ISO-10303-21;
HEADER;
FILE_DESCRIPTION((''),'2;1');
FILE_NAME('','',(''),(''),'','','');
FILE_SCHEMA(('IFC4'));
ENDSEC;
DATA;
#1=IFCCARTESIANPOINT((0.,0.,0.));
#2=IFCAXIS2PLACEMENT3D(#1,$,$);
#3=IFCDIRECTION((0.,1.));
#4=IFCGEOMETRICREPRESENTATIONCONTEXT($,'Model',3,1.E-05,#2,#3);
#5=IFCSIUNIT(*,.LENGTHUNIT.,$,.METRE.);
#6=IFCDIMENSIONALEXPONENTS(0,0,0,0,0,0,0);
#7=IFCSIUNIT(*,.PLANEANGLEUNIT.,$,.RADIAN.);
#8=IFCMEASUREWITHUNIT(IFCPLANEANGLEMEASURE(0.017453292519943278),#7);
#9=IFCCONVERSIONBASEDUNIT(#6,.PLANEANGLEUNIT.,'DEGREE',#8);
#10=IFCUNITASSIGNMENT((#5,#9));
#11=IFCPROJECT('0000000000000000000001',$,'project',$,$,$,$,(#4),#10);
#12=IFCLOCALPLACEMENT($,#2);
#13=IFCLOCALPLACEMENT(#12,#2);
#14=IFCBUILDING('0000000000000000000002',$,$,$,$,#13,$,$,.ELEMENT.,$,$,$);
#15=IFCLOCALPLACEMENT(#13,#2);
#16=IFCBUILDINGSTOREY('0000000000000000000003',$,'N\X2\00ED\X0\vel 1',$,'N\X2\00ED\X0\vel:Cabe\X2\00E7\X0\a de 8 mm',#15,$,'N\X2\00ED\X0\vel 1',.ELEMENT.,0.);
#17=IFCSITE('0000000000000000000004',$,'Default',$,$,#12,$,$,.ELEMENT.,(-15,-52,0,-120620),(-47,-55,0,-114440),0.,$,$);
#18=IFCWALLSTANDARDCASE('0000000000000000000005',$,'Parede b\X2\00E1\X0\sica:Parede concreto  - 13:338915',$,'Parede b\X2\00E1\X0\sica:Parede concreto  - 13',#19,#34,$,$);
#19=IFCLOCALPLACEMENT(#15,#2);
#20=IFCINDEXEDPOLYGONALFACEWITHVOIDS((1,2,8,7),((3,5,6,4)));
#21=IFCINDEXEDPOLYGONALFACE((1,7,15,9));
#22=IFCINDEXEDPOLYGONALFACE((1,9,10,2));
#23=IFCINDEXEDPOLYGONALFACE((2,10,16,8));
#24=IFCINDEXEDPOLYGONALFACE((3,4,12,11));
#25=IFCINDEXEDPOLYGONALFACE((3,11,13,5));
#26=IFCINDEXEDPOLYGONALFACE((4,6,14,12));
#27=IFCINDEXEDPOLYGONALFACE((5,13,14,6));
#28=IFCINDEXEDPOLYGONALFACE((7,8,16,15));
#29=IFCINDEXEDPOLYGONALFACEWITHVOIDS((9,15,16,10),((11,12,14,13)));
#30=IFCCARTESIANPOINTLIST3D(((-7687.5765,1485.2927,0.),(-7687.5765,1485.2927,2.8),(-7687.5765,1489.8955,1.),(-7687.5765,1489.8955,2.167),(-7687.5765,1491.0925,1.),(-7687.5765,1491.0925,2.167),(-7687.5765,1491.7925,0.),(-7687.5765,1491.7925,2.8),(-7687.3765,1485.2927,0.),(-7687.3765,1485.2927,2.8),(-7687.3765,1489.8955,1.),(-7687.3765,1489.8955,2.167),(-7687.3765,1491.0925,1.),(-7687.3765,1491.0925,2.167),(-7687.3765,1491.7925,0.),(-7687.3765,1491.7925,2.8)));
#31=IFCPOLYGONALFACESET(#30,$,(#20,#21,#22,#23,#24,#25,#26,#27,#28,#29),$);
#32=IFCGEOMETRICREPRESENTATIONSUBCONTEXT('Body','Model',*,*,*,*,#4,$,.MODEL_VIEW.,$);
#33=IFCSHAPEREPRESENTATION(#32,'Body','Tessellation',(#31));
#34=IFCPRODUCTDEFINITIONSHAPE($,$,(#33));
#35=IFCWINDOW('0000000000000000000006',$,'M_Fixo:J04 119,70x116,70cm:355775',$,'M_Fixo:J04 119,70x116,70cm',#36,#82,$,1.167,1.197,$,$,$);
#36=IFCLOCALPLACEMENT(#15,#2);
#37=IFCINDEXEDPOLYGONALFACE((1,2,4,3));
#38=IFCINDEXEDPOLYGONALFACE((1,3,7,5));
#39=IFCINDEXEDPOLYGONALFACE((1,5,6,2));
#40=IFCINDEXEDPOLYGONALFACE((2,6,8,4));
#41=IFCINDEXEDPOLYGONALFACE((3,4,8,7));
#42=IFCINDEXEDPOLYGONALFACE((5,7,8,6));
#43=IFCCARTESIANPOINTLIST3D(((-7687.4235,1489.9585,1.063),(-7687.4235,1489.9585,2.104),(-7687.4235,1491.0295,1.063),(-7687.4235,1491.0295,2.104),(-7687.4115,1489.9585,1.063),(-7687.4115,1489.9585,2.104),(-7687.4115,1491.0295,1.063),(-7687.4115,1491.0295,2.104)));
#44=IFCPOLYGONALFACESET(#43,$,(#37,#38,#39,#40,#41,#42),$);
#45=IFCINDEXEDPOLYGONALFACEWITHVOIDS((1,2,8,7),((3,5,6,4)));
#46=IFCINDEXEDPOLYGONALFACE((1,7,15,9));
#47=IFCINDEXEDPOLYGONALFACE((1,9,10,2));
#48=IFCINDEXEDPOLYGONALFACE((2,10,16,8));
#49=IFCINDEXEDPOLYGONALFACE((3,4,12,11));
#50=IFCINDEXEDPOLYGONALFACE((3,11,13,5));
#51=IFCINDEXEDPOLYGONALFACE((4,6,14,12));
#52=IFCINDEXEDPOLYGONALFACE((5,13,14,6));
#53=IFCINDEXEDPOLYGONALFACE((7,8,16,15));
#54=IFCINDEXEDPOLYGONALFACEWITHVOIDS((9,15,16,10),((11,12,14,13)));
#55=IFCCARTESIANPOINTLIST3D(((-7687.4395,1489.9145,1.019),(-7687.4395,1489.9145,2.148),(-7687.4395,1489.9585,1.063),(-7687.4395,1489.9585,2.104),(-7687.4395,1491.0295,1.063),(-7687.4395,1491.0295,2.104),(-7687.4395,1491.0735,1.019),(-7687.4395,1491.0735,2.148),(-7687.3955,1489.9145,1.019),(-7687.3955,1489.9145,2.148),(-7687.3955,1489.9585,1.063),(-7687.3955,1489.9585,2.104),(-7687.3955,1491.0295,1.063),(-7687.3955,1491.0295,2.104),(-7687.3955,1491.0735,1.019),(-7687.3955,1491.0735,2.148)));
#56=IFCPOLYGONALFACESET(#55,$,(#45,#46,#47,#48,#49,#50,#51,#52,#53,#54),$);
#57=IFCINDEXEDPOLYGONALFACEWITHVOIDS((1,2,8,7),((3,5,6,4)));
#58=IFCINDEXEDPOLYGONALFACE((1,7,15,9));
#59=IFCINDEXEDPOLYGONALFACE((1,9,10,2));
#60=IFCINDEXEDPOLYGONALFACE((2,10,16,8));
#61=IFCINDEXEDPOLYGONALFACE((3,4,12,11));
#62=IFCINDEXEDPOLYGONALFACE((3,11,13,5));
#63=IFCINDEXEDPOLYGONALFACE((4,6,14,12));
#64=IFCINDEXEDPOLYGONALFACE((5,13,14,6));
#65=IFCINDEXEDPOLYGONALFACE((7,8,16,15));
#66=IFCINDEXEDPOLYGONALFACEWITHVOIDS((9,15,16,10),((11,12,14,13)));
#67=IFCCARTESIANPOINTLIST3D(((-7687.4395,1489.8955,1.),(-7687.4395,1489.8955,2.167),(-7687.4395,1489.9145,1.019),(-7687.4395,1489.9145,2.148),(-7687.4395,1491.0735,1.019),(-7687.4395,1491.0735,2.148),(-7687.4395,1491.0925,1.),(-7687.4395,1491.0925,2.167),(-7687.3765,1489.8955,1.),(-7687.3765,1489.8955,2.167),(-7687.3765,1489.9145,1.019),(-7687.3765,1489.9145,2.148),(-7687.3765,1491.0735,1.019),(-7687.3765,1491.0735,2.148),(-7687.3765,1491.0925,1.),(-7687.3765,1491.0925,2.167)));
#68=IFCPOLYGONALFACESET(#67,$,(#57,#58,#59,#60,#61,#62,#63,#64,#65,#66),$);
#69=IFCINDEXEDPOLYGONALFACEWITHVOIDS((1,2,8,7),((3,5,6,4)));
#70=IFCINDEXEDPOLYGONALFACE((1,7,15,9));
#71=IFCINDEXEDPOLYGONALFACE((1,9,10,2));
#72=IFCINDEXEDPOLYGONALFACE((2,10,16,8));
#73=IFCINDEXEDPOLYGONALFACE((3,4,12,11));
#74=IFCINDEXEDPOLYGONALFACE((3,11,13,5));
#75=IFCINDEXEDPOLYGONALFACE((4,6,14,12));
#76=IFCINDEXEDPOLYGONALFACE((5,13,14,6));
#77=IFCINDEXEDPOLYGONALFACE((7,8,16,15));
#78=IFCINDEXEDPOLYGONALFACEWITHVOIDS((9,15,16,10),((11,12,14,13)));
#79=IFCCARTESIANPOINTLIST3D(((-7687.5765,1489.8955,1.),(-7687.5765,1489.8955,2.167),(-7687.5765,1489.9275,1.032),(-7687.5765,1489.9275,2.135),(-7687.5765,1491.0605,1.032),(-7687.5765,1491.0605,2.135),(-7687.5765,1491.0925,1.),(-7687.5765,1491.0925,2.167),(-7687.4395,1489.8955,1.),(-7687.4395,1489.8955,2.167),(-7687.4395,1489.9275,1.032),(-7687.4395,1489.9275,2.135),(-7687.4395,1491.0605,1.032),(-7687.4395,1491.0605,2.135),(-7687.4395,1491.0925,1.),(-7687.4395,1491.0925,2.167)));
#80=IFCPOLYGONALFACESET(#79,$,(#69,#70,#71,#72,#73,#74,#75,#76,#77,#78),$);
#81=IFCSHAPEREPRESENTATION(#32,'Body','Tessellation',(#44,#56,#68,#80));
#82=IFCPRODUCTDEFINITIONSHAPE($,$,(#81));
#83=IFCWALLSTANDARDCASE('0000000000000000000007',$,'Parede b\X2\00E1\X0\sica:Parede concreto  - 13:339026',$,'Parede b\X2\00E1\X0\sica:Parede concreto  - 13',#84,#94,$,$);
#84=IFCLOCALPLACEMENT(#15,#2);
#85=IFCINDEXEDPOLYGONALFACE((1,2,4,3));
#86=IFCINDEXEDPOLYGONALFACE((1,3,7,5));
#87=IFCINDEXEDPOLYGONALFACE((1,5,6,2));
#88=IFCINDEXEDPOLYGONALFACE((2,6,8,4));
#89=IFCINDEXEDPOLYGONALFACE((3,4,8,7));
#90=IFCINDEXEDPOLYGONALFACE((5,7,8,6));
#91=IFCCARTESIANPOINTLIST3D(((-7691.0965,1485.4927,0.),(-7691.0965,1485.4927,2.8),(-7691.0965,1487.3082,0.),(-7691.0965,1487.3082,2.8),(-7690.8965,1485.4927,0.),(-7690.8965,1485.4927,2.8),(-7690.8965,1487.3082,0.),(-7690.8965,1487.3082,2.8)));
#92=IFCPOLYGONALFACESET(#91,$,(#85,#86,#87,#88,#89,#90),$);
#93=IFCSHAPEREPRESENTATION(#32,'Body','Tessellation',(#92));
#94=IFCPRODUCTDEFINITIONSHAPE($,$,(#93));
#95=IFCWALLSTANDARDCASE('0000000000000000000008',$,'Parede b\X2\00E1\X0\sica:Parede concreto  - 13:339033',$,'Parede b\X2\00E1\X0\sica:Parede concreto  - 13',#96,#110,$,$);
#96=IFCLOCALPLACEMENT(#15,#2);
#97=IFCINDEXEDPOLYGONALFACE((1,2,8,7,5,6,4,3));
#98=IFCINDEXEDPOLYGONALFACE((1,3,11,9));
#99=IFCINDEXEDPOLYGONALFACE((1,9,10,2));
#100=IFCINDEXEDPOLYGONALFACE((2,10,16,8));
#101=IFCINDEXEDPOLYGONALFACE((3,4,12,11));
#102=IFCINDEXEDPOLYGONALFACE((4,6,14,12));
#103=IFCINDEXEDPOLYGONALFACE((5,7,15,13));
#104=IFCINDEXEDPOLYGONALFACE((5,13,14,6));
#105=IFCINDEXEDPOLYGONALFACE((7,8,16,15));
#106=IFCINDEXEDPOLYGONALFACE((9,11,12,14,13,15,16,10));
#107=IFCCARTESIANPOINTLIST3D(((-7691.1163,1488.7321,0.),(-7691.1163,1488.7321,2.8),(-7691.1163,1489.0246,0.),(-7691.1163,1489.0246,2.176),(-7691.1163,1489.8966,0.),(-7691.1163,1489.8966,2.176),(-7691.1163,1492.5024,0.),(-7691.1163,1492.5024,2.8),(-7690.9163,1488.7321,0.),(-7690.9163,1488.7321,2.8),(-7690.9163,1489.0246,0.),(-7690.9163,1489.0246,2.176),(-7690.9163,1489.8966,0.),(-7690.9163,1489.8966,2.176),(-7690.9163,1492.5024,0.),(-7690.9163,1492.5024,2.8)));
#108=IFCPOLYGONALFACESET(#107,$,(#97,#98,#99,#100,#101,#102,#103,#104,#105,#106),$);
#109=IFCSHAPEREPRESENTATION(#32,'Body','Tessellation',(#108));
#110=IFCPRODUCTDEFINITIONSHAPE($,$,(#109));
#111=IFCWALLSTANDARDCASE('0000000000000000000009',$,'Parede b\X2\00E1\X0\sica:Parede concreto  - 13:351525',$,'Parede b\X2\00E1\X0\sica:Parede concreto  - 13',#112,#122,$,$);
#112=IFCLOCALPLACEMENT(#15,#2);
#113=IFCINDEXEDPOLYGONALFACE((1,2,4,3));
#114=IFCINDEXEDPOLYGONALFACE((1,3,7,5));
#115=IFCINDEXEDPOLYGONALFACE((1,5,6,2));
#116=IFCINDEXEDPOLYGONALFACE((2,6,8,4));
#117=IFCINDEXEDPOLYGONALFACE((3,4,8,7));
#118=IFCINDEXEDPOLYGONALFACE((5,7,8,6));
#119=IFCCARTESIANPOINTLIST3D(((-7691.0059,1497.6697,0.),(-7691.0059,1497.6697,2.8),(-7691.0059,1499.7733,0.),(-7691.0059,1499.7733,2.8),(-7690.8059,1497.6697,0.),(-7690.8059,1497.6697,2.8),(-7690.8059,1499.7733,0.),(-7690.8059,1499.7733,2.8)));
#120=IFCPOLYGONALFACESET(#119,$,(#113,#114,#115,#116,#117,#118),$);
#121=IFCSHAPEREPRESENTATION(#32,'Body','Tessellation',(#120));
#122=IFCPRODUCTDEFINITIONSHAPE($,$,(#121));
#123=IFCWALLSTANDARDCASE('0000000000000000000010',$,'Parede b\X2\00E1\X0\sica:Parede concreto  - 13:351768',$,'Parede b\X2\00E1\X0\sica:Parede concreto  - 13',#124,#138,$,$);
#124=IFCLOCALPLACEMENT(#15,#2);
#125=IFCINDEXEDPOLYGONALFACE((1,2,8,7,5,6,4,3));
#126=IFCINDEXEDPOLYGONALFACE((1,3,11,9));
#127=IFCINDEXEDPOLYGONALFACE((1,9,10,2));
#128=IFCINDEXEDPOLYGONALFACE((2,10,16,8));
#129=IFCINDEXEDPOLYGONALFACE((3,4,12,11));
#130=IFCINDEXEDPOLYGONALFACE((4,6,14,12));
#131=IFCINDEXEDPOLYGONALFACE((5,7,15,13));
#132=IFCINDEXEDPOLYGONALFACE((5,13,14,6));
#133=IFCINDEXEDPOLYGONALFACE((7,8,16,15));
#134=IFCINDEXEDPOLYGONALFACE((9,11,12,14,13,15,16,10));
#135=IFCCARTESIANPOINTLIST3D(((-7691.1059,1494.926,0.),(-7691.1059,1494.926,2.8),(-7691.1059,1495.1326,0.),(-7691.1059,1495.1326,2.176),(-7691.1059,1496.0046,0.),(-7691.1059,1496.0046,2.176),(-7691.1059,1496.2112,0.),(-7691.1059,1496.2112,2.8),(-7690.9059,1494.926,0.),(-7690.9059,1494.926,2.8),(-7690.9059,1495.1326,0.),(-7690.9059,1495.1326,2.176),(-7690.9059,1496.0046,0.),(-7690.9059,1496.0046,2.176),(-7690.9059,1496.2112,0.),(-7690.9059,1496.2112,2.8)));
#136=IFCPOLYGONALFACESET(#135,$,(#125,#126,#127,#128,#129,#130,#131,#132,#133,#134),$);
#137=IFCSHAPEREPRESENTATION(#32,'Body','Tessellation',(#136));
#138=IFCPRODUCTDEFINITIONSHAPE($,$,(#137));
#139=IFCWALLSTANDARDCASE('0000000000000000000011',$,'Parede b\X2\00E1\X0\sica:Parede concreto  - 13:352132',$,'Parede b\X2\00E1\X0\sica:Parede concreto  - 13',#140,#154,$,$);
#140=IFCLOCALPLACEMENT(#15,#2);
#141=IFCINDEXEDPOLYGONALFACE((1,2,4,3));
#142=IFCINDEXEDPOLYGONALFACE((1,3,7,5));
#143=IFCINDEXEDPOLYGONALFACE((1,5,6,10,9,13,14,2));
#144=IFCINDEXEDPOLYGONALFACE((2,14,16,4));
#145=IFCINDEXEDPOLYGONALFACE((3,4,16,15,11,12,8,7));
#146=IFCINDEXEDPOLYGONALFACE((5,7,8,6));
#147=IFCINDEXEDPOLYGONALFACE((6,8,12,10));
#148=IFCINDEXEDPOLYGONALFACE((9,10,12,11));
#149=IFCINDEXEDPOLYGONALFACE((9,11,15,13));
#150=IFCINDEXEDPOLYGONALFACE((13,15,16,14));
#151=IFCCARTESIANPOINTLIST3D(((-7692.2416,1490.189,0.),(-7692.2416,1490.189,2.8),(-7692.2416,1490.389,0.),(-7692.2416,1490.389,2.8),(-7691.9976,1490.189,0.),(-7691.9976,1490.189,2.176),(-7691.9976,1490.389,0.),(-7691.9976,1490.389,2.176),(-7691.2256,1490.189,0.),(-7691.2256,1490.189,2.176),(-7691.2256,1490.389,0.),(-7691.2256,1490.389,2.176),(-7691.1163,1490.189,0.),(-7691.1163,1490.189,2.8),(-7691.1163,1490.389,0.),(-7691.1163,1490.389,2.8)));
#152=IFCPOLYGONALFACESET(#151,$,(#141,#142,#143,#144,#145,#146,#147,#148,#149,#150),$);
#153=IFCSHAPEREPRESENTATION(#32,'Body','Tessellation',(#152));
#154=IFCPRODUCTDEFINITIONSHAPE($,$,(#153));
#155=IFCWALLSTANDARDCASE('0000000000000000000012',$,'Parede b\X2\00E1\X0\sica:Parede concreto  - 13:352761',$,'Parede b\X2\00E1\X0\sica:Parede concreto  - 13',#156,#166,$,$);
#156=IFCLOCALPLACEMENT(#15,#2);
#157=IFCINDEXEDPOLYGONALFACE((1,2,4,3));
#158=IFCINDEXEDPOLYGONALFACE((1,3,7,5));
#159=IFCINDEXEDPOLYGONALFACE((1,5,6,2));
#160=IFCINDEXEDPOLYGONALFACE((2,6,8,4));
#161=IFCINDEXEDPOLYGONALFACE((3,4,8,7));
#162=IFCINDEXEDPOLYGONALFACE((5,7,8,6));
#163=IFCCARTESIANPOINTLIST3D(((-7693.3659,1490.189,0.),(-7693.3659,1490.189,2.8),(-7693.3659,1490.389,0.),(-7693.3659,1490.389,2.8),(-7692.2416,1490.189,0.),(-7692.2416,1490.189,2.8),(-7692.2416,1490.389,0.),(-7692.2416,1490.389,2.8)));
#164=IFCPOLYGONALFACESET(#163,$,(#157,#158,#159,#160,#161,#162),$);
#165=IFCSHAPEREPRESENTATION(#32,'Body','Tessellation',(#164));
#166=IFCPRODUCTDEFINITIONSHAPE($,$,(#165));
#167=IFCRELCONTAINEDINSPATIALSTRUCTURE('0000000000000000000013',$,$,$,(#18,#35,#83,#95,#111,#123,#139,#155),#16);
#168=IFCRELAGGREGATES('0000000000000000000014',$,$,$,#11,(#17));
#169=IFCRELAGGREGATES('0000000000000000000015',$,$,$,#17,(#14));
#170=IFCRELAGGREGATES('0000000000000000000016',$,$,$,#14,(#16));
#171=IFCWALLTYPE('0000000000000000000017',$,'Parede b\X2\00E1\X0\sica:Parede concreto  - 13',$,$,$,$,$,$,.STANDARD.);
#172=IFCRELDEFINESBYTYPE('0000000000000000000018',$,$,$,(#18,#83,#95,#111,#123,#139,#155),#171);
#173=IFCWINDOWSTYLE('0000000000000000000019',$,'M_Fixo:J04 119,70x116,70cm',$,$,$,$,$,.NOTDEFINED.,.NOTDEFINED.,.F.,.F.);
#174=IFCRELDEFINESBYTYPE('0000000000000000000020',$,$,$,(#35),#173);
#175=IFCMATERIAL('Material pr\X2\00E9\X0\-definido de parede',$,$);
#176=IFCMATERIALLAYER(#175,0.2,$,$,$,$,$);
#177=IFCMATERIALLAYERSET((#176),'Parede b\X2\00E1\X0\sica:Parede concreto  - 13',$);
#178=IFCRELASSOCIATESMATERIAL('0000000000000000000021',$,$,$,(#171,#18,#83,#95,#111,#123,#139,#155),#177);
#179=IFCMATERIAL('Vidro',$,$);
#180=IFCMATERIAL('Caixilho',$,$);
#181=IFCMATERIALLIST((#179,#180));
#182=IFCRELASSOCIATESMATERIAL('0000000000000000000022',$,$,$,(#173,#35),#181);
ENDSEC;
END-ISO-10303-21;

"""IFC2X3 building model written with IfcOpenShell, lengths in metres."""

from ifc_helpers import new_model, entity, si_unit, converted_unit, direction, frame, frame_2d, origin, place, context, subcontext, project, spatial, polyline, rectangle, outline, extrude, source, transform, mapped, material, material_list, layer, layer_set, layer_usage, type_object, type_shapes, element, fill, save


model = new_model("IFC2X3")

# Units and contexts
model_context = context("Model", 3, precision=1e-05, world=origin(), true_north=direction((0.0, 1.0)))
body_context = subcontext(model_context, "Body", "Model", "MODEL_VIEW")
ifc_project = project(units=[si_unit("LENGTHUNIT", "METRE"), converted_unit("PLANEANGLEUNIT", "DEGREE", entity("IfcPlaneAngleMeasure", 0.017453292519943278), si_unit("PLANEANGLEUNIT", "RADIAN"), dimensions=[0, 0, 0, 0, 0, 0, 0])], contexts=[model_context])

# Site, building, storey
site_placement = place(None, origin())
site = spatial("IfcSite", under=ifc_project, at=site_placement, Name="Default", CompositionType="ELEMENT", RefLatitude=(-15, -52, 0, -120620), RefLongitude=(-47, -55, 0, -114440), RefElevation=0.0)
building_placement = place(site_placement, origin())
building = spatial("IfcBuilding", under=site, at=building_placement, CompositionType="ELEMENT")
storey_placement = place(building_placement, origin())
storey = spatial("IfcBuildingStorey", under=building, at=storey_placement, Name="Nível 1", ObjectType="Nível:Cabeça de 8 mm", LongName="Nível 1", CompositionType="ELEMENT", Elevation=0.0)

# Shared definitions
ifc_material_1 = material(Name="Material pré-definido de parede")
ifc_layer_1 = layer(ifc_material_1, 0.2)
ifc_layer_set_1 = layer_set([ifc_layer_1], Name="Parede básica:Parede concreto  - 13")
wall_type = type_object("IfcWallType", Name="Parede básica:Parede concreto  - 13", PredefinedType="STANDARD", material=ifc_layer_set_1)
ifc_material_2 = material(Name="Vidro")
ifc_material_3 = material(Name="Caixilho")
ifc_material_list = material_list([ifc_material_2, ifc_material_3])
window_style = type_object("IfcWindowStyle", Name="M_Fixo:J04 119,70x116,70cm", ConstructionType="NOTDEFINED", OperationType="NOTDEFINED", ParameterTakesPrecedence=False, Sizeable=False, material=ifc_material_list)
shared_shape = source(origin(), body_context, "Body", "SweptSolid", [
    extrude(rectangle(XDim=0.012, YDim=1.071, at=frame_2d((0.0, 0.0), x_axis=(1.0, 0.0))), frame((0.5985, 0.159, 0.063), z_axis=(0.0, 0.0, 1.0), x_axis=(0.0, -1.0, 0.0)), (0.0, 0.0, 1.0), 1.041),
    extrude(outline(polyline([(-0.5795, -0.5645), (0.5795, -0.5645), (0.5795, 0.5645), (-0.5795, 0.5645), (-0.5795, -0.5645)]), holes=[polyline([(-0.5355, -0.5205), (-0.5355, 0.5205), (0.5355, 0.5205), (0.5355, -0.5205), (-0.5355, -0.5205)])]), frame((0.5985, 0.137, 0.5835), z_axis=(0.0, 1.0, 0.0), x_axis=(1.0, 0.0, 0.0)), (0.0, 0.0, 1.0), 0.044),
    extrude(outline(polyline([(-0.5985, -0.5835), (0.5985, -0.5835), (0.5985, 0.5835), (-0.5985, 0.5835), (-0.5985, -0.5835)]), holes=[polyline([(-0.5795, -0.5645), (-0.5795, 0.5645), (0.5795, 0.5645), (0.5795, -0.5645), (-0.5795, -0.5645)])]), frame((0.5985, 0.137, 0.5835), z_axis=(0.0, 1.0, 0.0), x_axis=(1.0, 0.0, 0.0)), (0.0, 0.0, 1.0), 0.063),
    extrude(outline(polyline([(-0.5985, -0.5835), (0.5985, -0.5835), (0.5985, 0.5835), (-0.5985, 0.5835), (-0.5985, -0.5835)]), holes=[polyline([(-0.5665, -0.5515), (-0.5665, 0.5515), (0.5665, 0.5515), (0.5665, -0.5515), (-0.5665, -0.5515)])]), frame((0.5985, 0.0, 0.5835), z_axis=(0.0, 1.0, 0.0), x_axis=(1.0, 0.0, 0.0)), (0.0, 0.0, 1.0), 0.137),
])
type_shapes(window_style, [shared_shape])

# Wall, opening, window
ifc_layer_usage_1 = layer_usage(ifc_layer_set_1, "AXIS2", "NEGATIVE", 0.1)
wall_1_placement = place(storey_placement, frame((-7687.4765, 1485.2927, 0.0), z_axis=(0.0, 0.0, 1.0), x_axis=(0.0, 1.0, 0.0)))
wall_1 = element("IfcWallStandardCase", 1, at=wall_1_placement, inside=storey, type_object=wall_type, material=ifc_layer_usage_1, Name="Parede básica:Parede concreto  - 13:338915", ObjectType="Parede básica:Parede concreto  - 13", context=body_context, shape_type="SweptSolid", body=[
    extrude(rectangle(XDim=6.4997, YDim=0.2, at=frame_2d((3.2499, 0.0), x_axis=(-1.0, 0.0))), origin(), (0.0, 0.0, 1.0), 2.8),
])
opening_1_placement = place(wall_1_placement, frame((5.7997, 0.1, 1.0)))
opening_1 = element("IfcOpeningElement", 2, at=opening_1_placement, cuts=wall_1, ObjectType="Opening", context=body_context, shape_type="SweptSolid", body=[
    extrude(rectangle(XDim=1.167, YDim=1.197, at=frame_2d((0.5835, 0.5985), x_axis=(1.0, 0.0))), frame((0.0, 0.0, 0.0), z_axis=(0.0, -1.0, 0.0), x_axis=(0.0, 0.0, 1.0)), (0.0, 0.0, 1.0), 0.2),
])
window_1_placement = place(opening_1_placement, frame((0.0, 0.0, 0.0), z_axis=(0.0, 0.0, 1.0), x_axis=(-1.0, 0.0, 0.0)))
window_1 = element("IfcWindow", 3, at=window_1_placement, inside=storey, type_object=window_style, material=ifc_material_list, Name="M_Fixo:J04 119,70x116,70cm:355775", ObjectType="M_Fixo:J04 119,70x116,70cm", OverallHeight=1.167, OverallWidth=1.197, context=body_context, shape_type="MappedRepresentation", body=[
    mapped(shared_shape, transform((0.0, 0.0, 0.0), scale=1.0)),
])
fill(opening_1, window_1)

# Wall
ifc_layer_usage_2 = layer_usage(ifc_layer_set_1, "AXIS2", "POSITIVE", -0.1)
wall_2_placement = place(storey_placement, frame((-7690.9965, 1485.4927, 0.0), z_axis=(0.0, 0.0, 1.0), x_axis=(0.0, 1.0, 0.0)))
element("IfcWallStandardCase", 4, at=wall_2_placement, inside=storey, type_object=wall_type, material=ifc_layer_usage_2, Name="Parede básica:Parede concreto  - 13:339026", ObjectType="Parede básica:Parede concreto  - 13", context=body_context, shape_type="SweptSolid", body=[
    extrude(rectangle(XDim=1.8154, YDim=0.2, at=frame_2d((0.9077, 0.0), x_axis=(-1.0, 0.0))), origin(), (0.0, 0.0, 1.0), 2.8),
])

# Wall, opening
ifc_layer_usage_3 = layer_usage(ifc_layer_set_1, "AXIS2", "POSITIVE", -0.1)
wall_3_placement = place(storey_placement, frame((-7691.0163, 1492.5024, 0.0), z_axis=(0.0, 0.0, 1.0), x_axis=(0.0, -1.0, 0.0)))
wall_3 = element("IfcWallStandardCase", 5, at=wall_3_placement, inside=storey, type_object=wall_type, material=ifc_layer_usage_3, Name="Parede básica:Parede concreto  - 13:339033", ObjectType="Parede básica:Parede concreto  - 13", context=body_context, shape_type="SweptSolid", body=[
    extrude(rectangle(XDim=3.7703, YDim=0.2, at=frame_2d((1.8852, 0.0), x_axis=(-1.0, 0.0))), origin(), (0.0, 0.0, 1.0), 2.8),
])
opening_2_placement = place(wall_3_placement, origin())
element("IfcOpeningElement", 6, at=opening_2_placement, cuts=wall_3, ObjectType="Opening", context=body_context, shape_type="SweptSolid", body=[
    extrude(rectangle(XDim=2.176, YDim=0.872, at=frame_2d((0.0, 0.0), x_axis=(0.0, 1.0))), frame((3.0419, 0.1, 1.088), z_axis=(0.0, -1.0, 0.0), x_axis=(1.0, 0.0, 0.0)), (0.0, 0.0, 1.0), 0.2),
])

# Wall
ifc_layer_usage_4 = layer_usage(ifc_layer_set_1, "AXIS2", "NEGATIVE", 0.1)
wall_4_placement = place(storey_placement, frame((-7690.9059, 1499.7733, 0.0), z_axis=(0.0, 0.0, 1.0), x_axis=(0.0, -1.0, 0.0)))
element("IfcWallStandardCase", 7, at=wall_4_placement, inside=storey, type_object=wall_type, material=ifc_layer_usage_4, Name="Parede básica:Parede concreto  - 13:351525", ObjectType="Parede básica:Parede concreto  - 13", context=body_context, shape_type="SweptSolid", body=[
    extrude(rectangle(XDim=2.1037, YDim=0.2, at=frame_2d((1.0518, 0.0), x_axis=(-1.0, 0.0))), origin(), (0.0, 0.0, 1.0), 2.8),
])

# Walls, openings
ifc_layer_usage_5 = layer_usage(ifc_layer_set_1, "AXIS2", "NEGATIVE", 0.1)
wall_5_placement = place(storey_placement, frame((-7691.0059, 1496.2112, 0.0), z_axis=(0.0, 0.0, 1.0), x_axis=(0.0, -1.0, 0.0)))
wall_5 = element("IfcWallStandardCase", 8, at=wall_5_placement, inside=storey, type_object=wall_type, material=ifc_layer_usage_5, Name="Parede básica:Parede concreto  - 13:351768", ObjectType="Parede básica:Parede concreto  - 13", context=body_context, shape_type="SweptSolid", body=[
    extrude(rectangle(XDim=1.2852, YDim=0.2, at=frame_2d((0.6426, 0.0), x_axis=(-1.0, 0.0))), origin(), (0.0, 0.0, 1.0), 2.8),
])
opening_3_placement = place(wall_5_placement, origin())
element("IfcOpeningElement", 9, at=opening_3_placement, cuts=wall_5, ObjectType="Opening", context=body_context, shape_type="SweptSolid", body=[
    extrude(rectangle(XDim=2.176, YDim=0.872, at=frame_2d((0.0, 0.0), x_axis=(0.0, 1.0))), frame((0.6426, 0.1, 1.088), z_axis=(0.0, -1.0, 0.0), x_axis=(1.0, 0.0, 0.0)), (0.0, 0.0, 1.0), 0.2),
])
ifc_layer_usage_6 = layer_usage(ifc_layer_set_1, "AXIS2", "POSITIVE", -0.1)
wall_6_placement = place(storey_placement, frame((-7692.2416, 1490.289, 0.0)))
wall_6 = element("IfcWallStandardCase", 10, at=wall_6_placement, inside=storey, type_object=wall_type, material=ifc_layer_usage_6, Name="Parede básica:Parede concreto  - 13:352132", ObjectType="Parede básica:Parede concreto  - 13", context=body_context, shape_type="SweptSolid", body=[
    extrude(rectangle(XDim=1.1253, YDim=0.2, at=frame_2d((0.5627, 0.0), x_axis=(-1.0, 0.0))), origin(), (0.0, 0.0, 1.0), 2.8),
])
opening_4_placement = place(wall_6_placement, origin())
element("IfcOpeningElement", 11, at=opening_4_placement, cuts=wall_6, ObjectType="Opening", context=body_context, shape_type="SweptSolid", body=[
    extrude(rectangle(XDim=2.176, YDim=0.772, at=frame_2d((0.0, 0.0), x_axis=(0.0, 1.0))), frame((0.63, 0.1, 1.088), z_axis=(0.0, -1.0, 0.0), x_axis=(1.0, 0.0, 0.0)), (0.0, 0.0, 1.0), 0.2),
])

# Wall
ifc_layer_usage_7 = layer_usage(ifc_layer_set_1, "AXIS2", "NEGATIVE", 0.1)
wall_7_placement = place(storey_placement, frame((-7692.2416, 1490.289, 0.0), z_axis=(0.0, 0.0, 1.0), x_axis=(-1.0, 0.0, 0.0)))
element("IfcWallStandardCase", 12, at=wall_7_placement, inside=storey, type_object=wall_type, material=ifc_layer_usage_7, Name="Parede básica:Parede concreto  - 13:352761", ObjectType="Parede básica:Parede concreto  - 13", context=body_context, shape_type="SweptSolid", body=[
    extrude(rectangle(XDim=1.1244, YDim=0.2, at=frame_2d((0.5622, 0.0), x_axis=(-1.0, 0.0))), origin(), (0.0, 0.0, 1.0), 2.8),
])

save(model, "model.ifc")
